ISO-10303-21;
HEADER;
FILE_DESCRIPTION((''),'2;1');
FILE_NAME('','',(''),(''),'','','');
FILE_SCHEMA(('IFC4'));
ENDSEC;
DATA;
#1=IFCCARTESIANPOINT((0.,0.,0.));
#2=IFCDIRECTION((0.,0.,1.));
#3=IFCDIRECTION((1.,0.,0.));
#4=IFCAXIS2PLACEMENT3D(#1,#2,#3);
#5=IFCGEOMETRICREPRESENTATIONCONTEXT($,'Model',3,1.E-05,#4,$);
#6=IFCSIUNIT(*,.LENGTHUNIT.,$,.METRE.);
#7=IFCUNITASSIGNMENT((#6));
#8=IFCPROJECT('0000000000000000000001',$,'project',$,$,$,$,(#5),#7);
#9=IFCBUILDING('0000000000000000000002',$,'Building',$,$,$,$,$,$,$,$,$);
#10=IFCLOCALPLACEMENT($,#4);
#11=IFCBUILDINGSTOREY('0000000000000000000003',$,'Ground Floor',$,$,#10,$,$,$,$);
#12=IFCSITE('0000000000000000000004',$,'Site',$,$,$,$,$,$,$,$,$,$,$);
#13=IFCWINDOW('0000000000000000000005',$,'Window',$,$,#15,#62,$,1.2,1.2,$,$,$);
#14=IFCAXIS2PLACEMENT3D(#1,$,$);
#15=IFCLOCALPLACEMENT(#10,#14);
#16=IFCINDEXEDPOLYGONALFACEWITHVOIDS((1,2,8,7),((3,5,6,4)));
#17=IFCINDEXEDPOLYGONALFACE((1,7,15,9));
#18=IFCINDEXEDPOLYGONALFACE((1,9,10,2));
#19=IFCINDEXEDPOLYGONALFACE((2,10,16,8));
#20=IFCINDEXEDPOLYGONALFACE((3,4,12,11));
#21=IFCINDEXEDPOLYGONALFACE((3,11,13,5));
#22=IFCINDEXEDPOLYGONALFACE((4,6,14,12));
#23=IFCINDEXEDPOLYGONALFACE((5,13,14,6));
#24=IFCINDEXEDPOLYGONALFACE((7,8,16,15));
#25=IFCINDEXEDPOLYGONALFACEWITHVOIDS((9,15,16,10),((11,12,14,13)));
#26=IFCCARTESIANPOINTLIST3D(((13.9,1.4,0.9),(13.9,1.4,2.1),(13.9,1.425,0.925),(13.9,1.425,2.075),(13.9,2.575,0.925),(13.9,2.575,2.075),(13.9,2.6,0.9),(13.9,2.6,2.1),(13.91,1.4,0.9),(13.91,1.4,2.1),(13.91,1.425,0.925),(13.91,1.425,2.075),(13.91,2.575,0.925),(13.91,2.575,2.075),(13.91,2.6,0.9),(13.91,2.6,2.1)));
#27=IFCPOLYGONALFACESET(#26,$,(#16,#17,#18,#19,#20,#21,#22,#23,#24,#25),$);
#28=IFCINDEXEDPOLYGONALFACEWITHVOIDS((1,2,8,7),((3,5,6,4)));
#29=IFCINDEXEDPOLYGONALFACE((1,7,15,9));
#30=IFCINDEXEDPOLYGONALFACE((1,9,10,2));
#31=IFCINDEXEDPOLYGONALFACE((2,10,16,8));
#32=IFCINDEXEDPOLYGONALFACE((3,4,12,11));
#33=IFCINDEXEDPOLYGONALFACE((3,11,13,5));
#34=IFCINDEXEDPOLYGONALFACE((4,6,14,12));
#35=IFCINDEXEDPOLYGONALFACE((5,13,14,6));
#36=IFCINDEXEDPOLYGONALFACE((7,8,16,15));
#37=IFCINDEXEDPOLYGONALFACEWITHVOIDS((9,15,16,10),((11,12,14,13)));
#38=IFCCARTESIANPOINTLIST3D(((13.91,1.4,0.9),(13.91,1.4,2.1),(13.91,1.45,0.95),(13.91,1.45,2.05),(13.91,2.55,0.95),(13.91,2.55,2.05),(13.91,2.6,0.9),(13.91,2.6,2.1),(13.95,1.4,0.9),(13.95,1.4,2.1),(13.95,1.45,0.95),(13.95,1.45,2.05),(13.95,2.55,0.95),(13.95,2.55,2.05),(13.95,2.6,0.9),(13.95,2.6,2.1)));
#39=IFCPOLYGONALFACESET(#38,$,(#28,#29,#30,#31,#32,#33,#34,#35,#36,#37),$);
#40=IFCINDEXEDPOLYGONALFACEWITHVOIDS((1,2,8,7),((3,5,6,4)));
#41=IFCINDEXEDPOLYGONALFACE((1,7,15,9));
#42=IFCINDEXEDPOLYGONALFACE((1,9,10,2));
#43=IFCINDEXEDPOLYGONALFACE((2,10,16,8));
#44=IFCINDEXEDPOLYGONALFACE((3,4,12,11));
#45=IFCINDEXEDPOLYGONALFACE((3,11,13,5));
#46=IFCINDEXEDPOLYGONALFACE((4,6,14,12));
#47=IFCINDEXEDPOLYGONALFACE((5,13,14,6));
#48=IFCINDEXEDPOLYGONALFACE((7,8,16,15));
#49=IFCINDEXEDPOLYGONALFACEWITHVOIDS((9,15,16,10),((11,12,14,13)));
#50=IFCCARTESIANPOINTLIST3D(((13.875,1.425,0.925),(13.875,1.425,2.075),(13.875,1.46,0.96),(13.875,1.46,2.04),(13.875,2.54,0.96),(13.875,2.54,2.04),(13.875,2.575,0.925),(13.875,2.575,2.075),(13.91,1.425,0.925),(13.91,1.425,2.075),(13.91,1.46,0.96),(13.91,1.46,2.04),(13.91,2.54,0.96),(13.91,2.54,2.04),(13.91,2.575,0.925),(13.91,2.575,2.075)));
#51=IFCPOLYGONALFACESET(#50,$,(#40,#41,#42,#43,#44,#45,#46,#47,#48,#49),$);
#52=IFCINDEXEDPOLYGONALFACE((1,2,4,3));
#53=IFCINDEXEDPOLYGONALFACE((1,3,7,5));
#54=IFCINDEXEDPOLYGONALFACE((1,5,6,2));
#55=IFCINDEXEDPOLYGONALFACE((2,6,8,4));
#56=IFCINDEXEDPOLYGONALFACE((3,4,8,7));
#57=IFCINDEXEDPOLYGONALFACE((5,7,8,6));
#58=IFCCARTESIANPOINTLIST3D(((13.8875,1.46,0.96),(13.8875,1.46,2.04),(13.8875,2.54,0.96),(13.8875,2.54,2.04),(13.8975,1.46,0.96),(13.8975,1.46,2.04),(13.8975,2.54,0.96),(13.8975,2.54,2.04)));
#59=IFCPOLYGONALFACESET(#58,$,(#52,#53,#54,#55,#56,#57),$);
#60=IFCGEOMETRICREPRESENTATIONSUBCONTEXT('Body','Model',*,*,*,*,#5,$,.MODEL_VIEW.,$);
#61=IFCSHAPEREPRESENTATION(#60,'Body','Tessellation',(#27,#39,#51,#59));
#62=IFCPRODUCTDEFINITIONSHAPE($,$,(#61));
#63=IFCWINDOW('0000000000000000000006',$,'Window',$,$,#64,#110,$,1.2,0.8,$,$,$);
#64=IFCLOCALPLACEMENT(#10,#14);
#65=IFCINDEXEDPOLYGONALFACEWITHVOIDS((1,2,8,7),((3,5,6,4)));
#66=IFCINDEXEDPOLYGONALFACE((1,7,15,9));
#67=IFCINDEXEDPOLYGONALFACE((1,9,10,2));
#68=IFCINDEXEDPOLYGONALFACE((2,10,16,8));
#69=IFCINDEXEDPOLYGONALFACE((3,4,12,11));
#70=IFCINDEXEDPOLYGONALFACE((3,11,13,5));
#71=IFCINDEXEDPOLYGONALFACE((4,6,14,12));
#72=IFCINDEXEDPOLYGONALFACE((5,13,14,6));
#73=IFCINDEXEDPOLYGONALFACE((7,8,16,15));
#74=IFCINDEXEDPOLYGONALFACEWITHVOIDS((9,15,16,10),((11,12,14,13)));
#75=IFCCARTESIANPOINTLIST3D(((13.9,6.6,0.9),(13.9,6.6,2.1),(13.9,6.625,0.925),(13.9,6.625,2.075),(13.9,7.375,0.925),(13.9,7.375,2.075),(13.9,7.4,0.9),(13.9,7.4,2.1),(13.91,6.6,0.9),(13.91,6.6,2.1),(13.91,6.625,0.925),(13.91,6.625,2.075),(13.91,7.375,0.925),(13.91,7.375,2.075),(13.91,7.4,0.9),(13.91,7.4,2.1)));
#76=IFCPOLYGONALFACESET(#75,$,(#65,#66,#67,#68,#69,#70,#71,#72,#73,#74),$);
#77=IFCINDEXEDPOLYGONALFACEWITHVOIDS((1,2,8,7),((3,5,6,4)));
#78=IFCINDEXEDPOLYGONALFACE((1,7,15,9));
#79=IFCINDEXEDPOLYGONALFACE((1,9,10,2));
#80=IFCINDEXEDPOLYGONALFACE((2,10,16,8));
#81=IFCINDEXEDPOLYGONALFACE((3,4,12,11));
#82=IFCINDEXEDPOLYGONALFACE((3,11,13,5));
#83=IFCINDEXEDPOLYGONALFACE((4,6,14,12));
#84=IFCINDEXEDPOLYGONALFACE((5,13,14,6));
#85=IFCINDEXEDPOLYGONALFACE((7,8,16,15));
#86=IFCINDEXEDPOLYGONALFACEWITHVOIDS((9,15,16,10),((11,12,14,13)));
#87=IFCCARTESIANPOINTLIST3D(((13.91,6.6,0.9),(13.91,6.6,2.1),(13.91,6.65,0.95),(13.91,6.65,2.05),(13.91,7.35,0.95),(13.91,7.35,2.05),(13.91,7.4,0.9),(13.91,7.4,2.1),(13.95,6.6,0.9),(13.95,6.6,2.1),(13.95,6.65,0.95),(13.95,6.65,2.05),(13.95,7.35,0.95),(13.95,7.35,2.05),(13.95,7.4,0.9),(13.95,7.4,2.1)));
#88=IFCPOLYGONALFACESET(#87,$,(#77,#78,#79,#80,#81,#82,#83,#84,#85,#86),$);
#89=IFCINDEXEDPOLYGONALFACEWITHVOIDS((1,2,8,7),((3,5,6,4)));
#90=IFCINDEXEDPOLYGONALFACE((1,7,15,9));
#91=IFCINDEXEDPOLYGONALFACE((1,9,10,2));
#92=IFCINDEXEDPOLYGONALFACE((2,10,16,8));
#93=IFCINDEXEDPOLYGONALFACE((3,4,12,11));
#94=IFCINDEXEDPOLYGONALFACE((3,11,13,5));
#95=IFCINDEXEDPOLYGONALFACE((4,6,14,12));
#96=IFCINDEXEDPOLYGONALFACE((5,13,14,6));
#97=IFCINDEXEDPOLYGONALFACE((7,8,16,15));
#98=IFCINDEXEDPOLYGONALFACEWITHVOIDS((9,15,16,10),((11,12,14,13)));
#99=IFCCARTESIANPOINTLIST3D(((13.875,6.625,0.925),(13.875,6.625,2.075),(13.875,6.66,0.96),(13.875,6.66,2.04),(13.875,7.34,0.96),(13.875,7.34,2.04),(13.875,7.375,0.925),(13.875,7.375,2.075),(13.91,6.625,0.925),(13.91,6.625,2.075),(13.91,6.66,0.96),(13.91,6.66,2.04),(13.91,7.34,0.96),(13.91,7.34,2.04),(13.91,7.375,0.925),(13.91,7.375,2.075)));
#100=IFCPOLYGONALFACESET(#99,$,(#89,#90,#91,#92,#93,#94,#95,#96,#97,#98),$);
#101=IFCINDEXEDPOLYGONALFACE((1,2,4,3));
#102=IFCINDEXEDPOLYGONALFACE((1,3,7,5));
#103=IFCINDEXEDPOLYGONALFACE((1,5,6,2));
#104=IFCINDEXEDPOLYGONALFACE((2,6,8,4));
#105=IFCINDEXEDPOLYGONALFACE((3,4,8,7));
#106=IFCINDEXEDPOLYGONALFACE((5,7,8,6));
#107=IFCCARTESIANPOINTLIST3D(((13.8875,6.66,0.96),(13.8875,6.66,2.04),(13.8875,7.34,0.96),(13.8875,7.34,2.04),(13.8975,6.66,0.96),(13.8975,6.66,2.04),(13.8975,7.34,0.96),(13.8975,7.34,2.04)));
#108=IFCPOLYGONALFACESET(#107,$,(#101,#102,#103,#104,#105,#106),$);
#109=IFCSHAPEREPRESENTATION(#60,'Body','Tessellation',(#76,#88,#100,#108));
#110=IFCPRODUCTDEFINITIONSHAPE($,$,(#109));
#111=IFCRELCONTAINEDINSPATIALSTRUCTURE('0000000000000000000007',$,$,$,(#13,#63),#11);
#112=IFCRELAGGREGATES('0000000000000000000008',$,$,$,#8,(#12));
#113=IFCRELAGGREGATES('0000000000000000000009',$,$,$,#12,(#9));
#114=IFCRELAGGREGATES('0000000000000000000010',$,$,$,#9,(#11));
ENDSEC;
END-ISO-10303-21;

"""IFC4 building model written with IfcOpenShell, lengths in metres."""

from ifc_helpers import new_model, si_unit, frame, origin_with_axes, place, context, subcontext, project, spatial, line, indexed_curve, outline, extrude, element, save


model = new_model("IFC4")

# Units and contexts
model_context = context("Model", 3, precision=1e-05, world=origin_with_axes())
body_context = subcontext(model_context, "Body", "Model", "MODEL_VIEW")
ifc_project = project(units=[si_unit("LENGTHUNIT", "METRE")], contexts=[model_context])

# Site, building, storey
site = spatial("IfcSite", under=ifc_project, Name="Site")
building = spatial("IfcBuilding", under=site, Name="Building")
storey_placement = place(None, origin_with_axes())
storey = spatial("IfcBuildingStorey", under=building, at=storey_placement, Name="Ground Floor")

# Windows
for number, where, z_axis, x_axis, name in (
    (1, (14.0, 1.4, 0.9), (0.0, 0.0, 1.0), (0.0, 1.0, 0.0), "Window"),
):
    element("IfcWindow", number, at=place(storey_placement, frame(where, z_axis=z_axis, x_axis=x_axis)), inside=storey, Name=name, OverallHeight=1.2, OverallWidth=1.2, context=body_context, shape_type="SweptSolid", body=[
        extrude(outline(indexed_curve([(0.0, 0.0), (1.2, 0.0), (1.2, 1.2), (0.0, 1.2)], segments=[line(1, 2, 3, 4, 1)]), holes=[indexed_curve([(0.025, 0.025), (1.175, 0.025), (1.175, 1.175), (0.025, 1.175)], segments=[line(1, 2, 3, 4, 1)])]), frame((0.0, 0.09, 0.0), z_axis=(0.0, -1.0, 0.0), x_axis=(1.0, 0.0, 0.0)), (0.0, 0.0, -1.0), 0.01),
        extrude(outline(indexed_curve([(0.0, 0.0), (1.2, 0.0), (1.2, 1.2), (0.0, 1.2)], segments=[line(1, 2, 3, 4, 1)]), holes=[indexed_curve([(0.05, 0.05), (1.15, 0.05), (1.15, 1.15), (0.05, 1.15)], segments=[line(1, 2, 3, 4, 1)])]), frame((0.0, 0.05, 0.0), z_axis=(0.0, -1.0, 0.0), x_axis=(1.0, 0.0, 0.0)), (0.0, 0.0, -1.0), 0.04),
        extrude(outline(indexed_curve([(0.0, 0.0), (1.15, 0.0), (1.15, 1.15), (0.0, 1.15)], segments=[line(1, 2, 3, 4, 1)]), holes=[indexed_curve([(0.035, 0.035), (1.115, 0.035), (1.115, 1.115), (0.035, 1.115)], segments=[line(1, 2, 3, 4, 1)])]), frame((0.025, 0.09, 0.025), z_axis=(0.0, -1.0, 0.0), x_axis=(1.0, 0.0, 0.0)), (0.0, 0.0, -1.0), 0.035),
        extrude(outline(indexed_curve([(0.035, 0.035), (1.115, 0.035), (1.115, 1.115), (0.035, 1.115)], segments=[line(1, 2, 3, 4, 1)])), frame((0.025, 0.1025, 0.025), z_axis=(0.0, -1.0, 0.0), x_axis=(1.0, 0.0, 0.0)), (0.0, 0.0, -1.0), 0.01),
    ])
window_1_placement = place(storey_placement, frame((14.0, 6.6, 0.9), z_axis=(0.0, 0.0, 1.0), x_axis=(0.0, 1.0, 0.0)))
element("IfcWindow", 2, at=window_1_placement, inside=storey, Name="Window", OverallHeight=1.2, OverallWidth=0.8, context=body_context, shape_type="SweptSolid", body=[
    extrude(outline(indexed_curve([(0.0, 0.0), (0.8, 0.0), (0.8, 1.2), (0.0, 1.2)], segments=[line(1, 2, 3, 4, 1)]), holes=[indexed_curve([(0.025, 0.025), (0.775, 0.025), (0.775, 1.175), (0.025, 1.175)], segments=[line(1, 2, 3, 4, 1)])]), frame((0.0, 0.09, 0.0), z_axis=(0.0, -1.0, 0.0), x_axis=(1.0, 0.0, 0.0)), (0.0, 0.0, -1.0), 0.01),
    extrude(outline(indexed_curve([(0.0, 0.0), (0.8, 0.0), (0.8, 1.2), (0.0, 1.2)], segments=[line(1, 2, 3, 4, 1)]), holes=[indexed_curve([(0.05, 0.05), (0.75, 0.05), (0.75, 1.15), (0.05, 1.15)], segments=[line(1, 2, 3, 4, 1)])]), frame((0.0, 0.05, 0.0), z_axis=(0.0, -1.0, 0.0), x_axis=(1.0, 0.0, 0.0)), (0.0, 0.0, -1.0), 0.04),
    extrude(outline(indexed_curve([(0.0, 0.0), (0.75, 0.0), (0.75, 1.15), (0.0, 1.15)], segments=[line(1, 2, 3, 4, 1)]), holes=[indexed_curve([(0.035, 0.035), (0.715, 0.035), (0.715, 1.115), (0.035, 1.115)], segments=[line(1, 2, 3, 4, 1)])]), frame((0.025, 0.09, 0.025), z_axis=(0.0, -1.0, 0.0), x_axis=(1.0, 0.0, 0.0)), (0.0, 0.0, -1.0), 0.035),
    extrude(outline(indexed_curve([(0.035, 0.035), (0.715, 0.035), (0.715, 1.115), (0.035, 1.115)], segments=[line(1, 2, 3, 4, 1)])), frame((0.025, 0.1025, 0.025), z_axis=(0.0, -1.0, 0.0), x_axis=(1.0, 0.0, 0.0)), (0.0, 0.0, -1.0), 0.01),
])

save(model, "model.ifc")
